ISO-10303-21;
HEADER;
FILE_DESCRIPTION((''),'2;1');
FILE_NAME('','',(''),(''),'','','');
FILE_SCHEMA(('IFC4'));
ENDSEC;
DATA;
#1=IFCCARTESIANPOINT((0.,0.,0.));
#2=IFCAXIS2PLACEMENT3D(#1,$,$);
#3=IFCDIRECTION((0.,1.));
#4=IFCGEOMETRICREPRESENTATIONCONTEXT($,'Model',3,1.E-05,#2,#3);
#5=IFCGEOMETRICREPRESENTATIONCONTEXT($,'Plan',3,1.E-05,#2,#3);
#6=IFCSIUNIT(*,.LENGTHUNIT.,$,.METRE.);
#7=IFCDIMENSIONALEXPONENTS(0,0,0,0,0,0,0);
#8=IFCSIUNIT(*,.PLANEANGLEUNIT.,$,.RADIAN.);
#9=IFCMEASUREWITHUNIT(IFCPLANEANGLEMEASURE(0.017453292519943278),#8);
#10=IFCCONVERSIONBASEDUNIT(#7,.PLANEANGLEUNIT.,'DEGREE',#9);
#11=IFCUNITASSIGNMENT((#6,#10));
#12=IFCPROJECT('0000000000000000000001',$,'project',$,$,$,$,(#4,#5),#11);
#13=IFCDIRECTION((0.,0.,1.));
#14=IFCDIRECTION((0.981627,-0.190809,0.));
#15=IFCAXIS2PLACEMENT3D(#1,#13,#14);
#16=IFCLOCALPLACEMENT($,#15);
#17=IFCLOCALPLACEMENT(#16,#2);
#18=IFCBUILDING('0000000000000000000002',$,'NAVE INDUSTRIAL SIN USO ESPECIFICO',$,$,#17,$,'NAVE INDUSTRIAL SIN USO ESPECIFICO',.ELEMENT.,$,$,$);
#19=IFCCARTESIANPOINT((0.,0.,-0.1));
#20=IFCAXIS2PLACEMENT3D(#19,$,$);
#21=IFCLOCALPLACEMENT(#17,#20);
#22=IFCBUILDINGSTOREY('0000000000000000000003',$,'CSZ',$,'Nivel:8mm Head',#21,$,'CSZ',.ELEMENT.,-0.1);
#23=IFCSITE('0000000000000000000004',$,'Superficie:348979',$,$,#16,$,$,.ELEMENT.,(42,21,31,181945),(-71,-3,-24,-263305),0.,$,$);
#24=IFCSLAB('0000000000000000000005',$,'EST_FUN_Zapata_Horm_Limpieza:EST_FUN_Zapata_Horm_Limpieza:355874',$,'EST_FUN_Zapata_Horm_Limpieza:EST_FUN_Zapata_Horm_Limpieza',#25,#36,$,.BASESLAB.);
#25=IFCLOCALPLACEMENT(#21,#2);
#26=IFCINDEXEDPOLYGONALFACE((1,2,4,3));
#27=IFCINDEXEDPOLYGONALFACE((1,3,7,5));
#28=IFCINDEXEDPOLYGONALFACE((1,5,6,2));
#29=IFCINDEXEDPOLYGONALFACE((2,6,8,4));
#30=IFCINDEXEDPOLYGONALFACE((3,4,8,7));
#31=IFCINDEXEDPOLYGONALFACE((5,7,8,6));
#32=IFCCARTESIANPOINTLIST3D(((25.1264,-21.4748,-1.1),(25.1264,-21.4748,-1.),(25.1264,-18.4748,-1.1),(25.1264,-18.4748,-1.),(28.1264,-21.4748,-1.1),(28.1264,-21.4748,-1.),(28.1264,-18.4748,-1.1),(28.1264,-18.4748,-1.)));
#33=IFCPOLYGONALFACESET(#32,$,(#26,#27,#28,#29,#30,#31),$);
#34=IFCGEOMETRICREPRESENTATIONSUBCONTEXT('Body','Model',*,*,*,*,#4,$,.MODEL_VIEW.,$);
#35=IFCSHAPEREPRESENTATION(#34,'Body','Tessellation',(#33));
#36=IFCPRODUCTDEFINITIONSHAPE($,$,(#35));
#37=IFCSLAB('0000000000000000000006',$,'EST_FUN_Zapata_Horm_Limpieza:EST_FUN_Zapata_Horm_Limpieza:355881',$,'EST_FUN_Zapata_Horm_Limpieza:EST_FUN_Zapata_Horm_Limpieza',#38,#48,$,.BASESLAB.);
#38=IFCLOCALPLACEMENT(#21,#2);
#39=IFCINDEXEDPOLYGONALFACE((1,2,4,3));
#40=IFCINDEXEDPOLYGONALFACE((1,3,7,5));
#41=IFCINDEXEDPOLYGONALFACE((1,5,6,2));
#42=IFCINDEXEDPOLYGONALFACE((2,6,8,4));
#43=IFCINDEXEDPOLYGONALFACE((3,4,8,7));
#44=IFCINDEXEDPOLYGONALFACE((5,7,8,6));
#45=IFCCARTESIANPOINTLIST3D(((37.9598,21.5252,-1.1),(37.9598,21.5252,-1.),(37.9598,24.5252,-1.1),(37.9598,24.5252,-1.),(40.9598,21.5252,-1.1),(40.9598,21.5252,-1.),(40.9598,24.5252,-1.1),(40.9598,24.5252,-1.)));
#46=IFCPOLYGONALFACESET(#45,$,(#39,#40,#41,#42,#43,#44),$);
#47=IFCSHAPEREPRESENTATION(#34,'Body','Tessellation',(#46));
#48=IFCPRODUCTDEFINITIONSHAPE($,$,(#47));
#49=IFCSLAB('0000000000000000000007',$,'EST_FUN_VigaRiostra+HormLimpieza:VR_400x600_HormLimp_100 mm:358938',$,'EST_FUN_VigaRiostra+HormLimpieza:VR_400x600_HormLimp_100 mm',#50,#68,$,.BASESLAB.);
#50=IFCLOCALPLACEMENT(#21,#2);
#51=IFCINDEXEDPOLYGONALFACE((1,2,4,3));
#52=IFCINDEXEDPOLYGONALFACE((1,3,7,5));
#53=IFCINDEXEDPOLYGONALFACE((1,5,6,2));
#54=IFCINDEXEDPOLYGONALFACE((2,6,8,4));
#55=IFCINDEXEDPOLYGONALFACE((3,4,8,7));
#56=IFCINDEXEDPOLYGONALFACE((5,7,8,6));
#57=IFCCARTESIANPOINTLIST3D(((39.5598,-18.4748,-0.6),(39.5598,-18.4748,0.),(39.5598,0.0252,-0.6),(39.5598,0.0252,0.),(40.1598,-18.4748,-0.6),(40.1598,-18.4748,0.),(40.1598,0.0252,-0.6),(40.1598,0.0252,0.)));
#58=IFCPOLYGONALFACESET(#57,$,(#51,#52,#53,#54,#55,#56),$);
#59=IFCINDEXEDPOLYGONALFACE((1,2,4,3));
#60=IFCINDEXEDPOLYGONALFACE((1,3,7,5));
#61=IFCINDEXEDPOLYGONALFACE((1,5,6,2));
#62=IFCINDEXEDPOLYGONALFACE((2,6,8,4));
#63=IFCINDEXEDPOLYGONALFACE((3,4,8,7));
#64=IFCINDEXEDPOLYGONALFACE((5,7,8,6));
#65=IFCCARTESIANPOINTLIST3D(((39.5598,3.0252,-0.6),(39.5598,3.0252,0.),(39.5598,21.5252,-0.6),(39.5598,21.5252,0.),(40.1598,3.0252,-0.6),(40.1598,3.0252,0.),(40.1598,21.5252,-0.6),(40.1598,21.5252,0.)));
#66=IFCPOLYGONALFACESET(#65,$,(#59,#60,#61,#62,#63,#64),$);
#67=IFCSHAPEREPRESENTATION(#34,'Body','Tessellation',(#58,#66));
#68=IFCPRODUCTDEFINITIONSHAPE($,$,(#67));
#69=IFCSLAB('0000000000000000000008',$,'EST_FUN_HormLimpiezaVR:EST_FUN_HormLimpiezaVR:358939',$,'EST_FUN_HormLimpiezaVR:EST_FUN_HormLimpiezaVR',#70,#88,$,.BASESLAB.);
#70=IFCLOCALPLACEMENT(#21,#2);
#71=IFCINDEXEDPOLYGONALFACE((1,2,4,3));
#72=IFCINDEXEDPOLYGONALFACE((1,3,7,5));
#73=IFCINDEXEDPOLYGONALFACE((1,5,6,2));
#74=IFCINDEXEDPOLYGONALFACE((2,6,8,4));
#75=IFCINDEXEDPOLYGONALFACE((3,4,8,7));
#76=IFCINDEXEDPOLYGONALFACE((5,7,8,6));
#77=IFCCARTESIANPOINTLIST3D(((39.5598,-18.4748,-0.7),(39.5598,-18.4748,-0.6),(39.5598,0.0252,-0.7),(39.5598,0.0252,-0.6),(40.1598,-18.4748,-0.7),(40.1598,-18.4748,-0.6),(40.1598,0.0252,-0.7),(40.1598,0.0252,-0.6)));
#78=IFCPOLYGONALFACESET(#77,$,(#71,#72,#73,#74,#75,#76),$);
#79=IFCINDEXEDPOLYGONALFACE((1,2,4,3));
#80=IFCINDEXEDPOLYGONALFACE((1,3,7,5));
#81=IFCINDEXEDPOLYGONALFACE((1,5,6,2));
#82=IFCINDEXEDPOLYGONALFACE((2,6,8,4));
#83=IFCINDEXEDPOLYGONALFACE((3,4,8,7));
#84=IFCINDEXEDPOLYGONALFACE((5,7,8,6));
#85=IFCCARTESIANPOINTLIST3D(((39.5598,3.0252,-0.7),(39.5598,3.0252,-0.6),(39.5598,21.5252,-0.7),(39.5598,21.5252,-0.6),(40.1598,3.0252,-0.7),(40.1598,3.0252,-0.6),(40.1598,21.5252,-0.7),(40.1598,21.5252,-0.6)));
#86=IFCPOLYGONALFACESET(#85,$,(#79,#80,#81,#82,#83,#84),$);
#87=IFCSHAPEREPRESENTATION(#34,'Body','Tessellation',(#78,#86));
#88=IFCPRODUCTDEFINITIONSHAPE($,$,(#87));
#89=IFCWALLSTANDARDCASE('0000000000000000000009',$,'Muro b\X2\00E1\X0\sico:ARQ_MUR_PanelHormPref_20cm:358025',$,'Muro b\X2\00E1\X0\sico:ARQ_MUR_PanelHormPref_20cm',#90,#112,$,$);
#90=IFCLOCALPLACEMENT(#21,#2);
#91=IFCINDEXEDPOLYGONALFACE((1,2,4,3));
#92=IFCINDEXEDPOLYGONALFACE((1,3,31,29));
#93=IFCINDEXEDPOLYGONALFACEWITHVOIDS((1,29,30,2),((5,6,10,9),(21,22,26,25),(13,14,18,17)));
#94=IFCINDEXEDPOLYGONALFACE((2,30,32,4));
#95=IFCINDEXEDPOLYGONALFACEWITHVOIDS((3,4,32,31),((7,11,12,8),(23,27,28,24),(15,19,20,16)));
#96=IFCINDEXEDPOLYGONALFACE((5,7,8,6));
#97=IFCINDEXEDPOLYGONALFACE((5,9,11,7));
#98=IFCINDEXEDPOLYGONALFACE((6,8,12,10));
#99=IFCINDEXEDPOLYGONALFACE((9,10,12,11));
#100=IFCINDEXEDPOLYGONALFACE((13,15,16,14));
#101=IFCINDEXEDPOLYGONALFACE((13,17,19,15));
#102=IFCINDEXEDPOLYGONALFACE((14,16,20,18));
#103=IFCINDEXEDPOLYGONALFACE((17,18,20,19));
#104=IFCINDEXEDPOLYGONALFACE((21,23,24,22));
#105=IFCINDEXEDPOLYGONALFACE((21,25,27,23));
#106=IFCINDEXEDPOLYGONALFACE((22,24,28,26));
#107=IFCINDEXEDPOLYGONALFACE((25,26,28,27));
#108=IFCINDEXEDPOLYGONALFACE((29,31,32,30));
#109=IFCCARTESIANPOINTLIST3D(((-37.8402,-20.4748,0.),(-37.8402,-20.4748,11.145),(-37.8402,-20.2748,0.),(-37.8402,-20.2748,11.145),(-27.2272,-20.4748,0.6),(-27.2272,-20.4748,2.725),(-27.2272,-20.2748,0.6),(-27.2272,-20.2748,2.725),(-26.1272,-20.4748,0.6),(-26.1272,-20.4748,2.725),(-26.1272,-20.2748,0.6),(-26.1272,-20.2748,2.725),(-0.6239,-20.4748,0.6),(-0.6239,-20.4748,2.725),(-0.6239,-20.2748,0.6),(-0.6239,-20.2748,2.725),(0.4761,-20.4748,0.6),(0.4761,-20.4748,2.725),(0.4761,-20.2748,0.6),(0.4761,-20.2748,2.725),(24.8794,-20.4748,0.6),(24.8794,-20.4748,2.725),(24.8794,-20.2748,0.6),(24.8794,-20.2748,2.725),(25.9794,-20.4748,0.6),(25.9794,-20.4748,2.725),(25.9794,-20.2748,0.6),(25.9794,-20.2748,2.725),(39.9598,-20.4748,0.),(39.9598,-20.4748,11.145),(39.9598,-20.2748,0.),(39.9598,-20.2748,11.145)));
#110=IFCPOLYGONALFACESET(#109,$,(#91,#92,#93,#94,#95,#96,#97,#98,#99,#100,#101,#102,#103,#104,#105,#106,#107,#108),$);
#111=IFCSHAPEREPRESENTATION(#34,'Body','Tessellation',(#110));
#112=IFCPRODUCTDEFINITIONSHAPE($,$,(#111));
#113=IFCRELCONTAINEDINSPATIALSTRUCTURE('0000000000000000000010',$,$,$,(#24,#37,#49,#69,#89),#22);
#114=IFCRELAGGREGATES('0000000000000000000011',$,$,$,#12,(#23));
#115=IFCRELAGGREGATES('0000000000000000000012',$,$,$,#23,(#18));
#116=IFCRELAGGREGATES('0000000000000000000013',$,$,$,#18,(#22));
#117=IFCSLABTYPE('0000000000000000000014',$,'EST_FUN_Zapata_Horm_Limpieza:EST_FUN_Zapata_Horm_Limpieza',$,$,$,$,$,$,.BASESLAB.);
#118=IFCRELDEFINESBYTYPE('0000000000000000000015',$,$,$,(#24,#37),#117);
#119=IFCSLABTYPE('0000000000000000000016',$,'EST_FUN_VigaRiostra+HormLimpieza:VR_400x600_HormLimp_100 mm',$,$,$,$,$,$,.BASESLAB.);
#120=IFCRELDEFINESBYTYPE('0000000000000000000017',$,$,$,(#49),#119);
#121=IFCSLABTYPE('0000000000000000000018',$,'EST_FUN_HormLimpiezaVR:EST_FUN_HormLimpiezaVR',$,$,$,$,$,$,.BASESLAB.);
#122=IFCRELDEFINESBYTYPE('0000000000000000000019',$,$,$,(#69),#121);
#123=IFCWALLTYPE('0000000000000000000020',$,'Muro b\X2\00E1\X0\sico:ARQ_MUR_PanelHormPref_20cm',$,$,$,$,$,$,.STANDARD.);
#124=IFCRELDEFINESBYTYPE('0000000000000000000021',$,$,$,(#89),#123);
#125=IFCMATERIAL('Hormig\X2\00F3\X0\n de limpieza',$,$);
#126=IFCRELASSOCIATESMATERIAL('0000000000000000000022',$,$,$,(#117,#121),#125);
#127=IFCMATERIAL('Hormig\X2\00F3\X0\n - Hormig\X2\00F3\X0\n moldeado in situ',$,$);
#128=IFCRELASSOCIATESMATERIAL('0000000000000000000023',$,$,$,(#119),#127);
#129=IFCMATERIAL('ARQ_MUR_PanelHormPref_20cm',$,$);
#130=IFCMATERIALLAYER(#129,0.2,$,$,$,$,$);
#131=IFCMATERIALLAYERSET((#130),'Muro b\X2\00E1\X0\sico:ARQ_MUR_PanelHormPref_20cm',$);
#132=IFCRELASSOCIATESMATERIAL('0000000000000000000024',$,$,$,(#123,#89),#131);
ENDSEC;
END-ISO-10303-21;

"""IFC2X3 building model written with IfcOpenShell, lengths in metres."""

from ifc_helpers import new_model, entity, si_unit, converted_unit, direction, frame, frame_2d, origin, origin_2d_with_axis, place, context, subcontext, project, spatial, rectangle, extrude, material, layer, layer_set, layer_usage, type_object, element, save


model = new_model("IFC2X3")

# Units and contexts
model_context = context("Model", 3, precision=1e-05, world=origin(), true_north=direction((0.0, 1.0)))
plan_context = context("Plan", 3, precision=1e-05, world=origin(), true_north=direction((0.0, 1.0)))
body_context = subcontext(model_context, "Body", "Model", "MODEL_VIEW")
ifc_project = project(units=[si_unit("LENGTHUNIT", "METRE"), converted_unit("PLANEANGLEUNIT", "DEGREE", entity("IfcPlaneAngleMeasure", 0.017453292519943278), si_unit("PLANEANGLEUNIT", "RADIAN"), dimensions=[0, 0, 0, 0, 0, 0, 0])], contexts=[model_context, plan_context])

# Site, building, storey
site_placement = place(None, frame((0.0, 0.0, 0.0), z_axis=(0.0, 0.0, 1.0), x_axis=(0.981627, -0.190809, 0.0)))
site = spatial("IfcSite", under=ifc_project, at=site_placement, Name="Superficie:348979", CompositionType="ELEMENT", RefLatitude=(42, 21, 31, 181945), RefLongitude=(-71, -3, -24, -263305), RefElevation=0.0)
building_placement = place(site_placement, origin())
building = spatial("IfcBuilding", under=site, at=building_placement, Name="NAVE INDUSTRIAL SIN USO ESPECIFICO", LongName="NAVE INDUSTRIAL SIN USO ESPECIFICO", CompositionType="ELEMENT")
storey_placement = place(building_placement, frame((0.0, 0.0, -0.1)))
storey = spatial("IfcBuildingStorey", under=building, at=storey_placement, Name="CSZ", ObjectType="Nivel:8mm Head", LongName="CSZ", CompositionType="ELEMENT", Elevation=-0.1)

# Slabs
ifc_material_1 = material(Name="Hormigón - Hormigón moldeado in situ")
ifc_material_2 = material(Name="Hormigón de limpieza")
slab_type_1 = type_object("IfcSlabType", Name="EST_FUN_Zapata_Horm_Limpieza:EST_FUN_Zapata_Horm_Limpieza", PredefinedType="BASESLAB", material=ifc_material_2)
slab_1_placement = place(storey_placement, frame((0.0, 0.0, -1.0)))
element("IfcSlab", 1, at=slab_1_placement, inside=storey, type_object=slab_type_1, Name="EST_FUN_Zapata_Horm_Limpieza:EST_FUN_Zapata_Horm_Limpieza:355874", ObjectType="EST_FUN_Zapata_Horm_Limpieza:EST_FUN_Zapata_Horm_Limpieza", PredefinedType="BASESLAB", context=body_context, shape_type="SweptSolid", body=[
    extrude(rectangle(XDim=3.0, YDim=3.0, at=frame_2d((0.0, 0.0), x_axis=(1.0, 0.0))), frame((26.6264, -19.9748, -0.1)), (0.0, 0.0, 1.0), 0.1),
])
slab_2_placement = place(storey_placement, frame((0.0, 0.0, -1.0)))
element("IfcSlab", 2, at=slab_2_placement, inside=storey, type_object=slab_type_1, Name="EST_FUN_Zapata_Horm_Limpieza:EST_FUN_Zapata_Horm_Limpieza:355881", ObjectType="EST_FUN_Zapata_Horm_Limpieza:EST_FUN_Zapata_Horm_Limpieza", PredefinedType="BASESLAB", context=body_context, shape_type="SweptSolid", body=[
    extrude(rectangle(XDim=3.0, YDim=3.0, at=frame_2d((0.0, 0.0), x_axis=(1.0, 0.0))), frame((39.4598, 23.0252, -0.1)), (0.0, 0.0, 1.0), 0.1),
])
slab_type_2 = type_object("IfcSlabType", Name="EST_FUN_VigaRiostra+HormLimpieza:VR_400x600_HormLimp_100 mm", PredefinedType="BASESLAB", material=ifc_material_1)
slab_3_placement = place(storey_placement, frame((39.5598, -18.4748, -0.6)))
element("IfcSlab", 3, at=slab_3_placement, inside=storey, type_object=slab_type_2, Name="EST_FUN_VigaRiostra+HormLimpieza:VR_400x600_HormLimp_100 mm:358938", ObjectType="EST_FUN_VigaRiostra+HormLimpieza:VR_400x600_HormLimp_100 mm", PredefinedType="BASESLAB", context=body_context, shape_type="SweptSolid", body=[
    extrude(rectangle(XDim=18.5, YDim=0.6, at=origin_2d_with_axis()), frame((0.3, 9.25, 0.0), z_axis=(0.0, 0.0, 1.0), x_axis=(0.0, -1.0, 0.0)), (0.0, 0.0, 1.0), 0.6),
    extrude(rectangle(XDim=18.5, YDim=0.6, at=origin_2d_with_axis()), frame((0.3, 30.75, 0.0), z_axis=(0.0, 0.0, 1.0), x_axis=(0.0, -1.0, 0.0)), (0.0, 0.0, 1.0), 0.6),
])
slab_type_3 = type_object("IfcSlabType", Name="EST_FUN_HormLimpiezaVR:EST_FUN_HormLimpiezaVR", PredefinedType="BASESLAB", material=ifc_material_2)
slab_4_placement = place(storey_placement, frame((39.5598, -18.4748, -0.7)))
element("IfcSlab", 4, at=slab_4_placement, inside=storey, type_object=slab_type_3, Name="EST_FUN_HormLimpiezaVR:EST_FUN_HormLimpiezaVR:358939", ObjectType="EST_FUN_HormLimpiezaVR:EST_FUN_HormLimpiezaVR", PredefinedType="BASESLAB", context=body_context, shape_type="SweptSolid", body=[
    extrude(rectangle(XDim=18.5, YDim=0.6, at=frame_2d((0.0, 0.0), x_axis=(1.0, 0.0))), frame((0.3, 9.25, 0.0), z_axis=(0.0, 0.0, 1.0), x_axis=(0.0, -1.0, 0.0)), (0.0, 0.0, 1.0), 0.1),
    extrude(rectangle(XDim=18.5, YDim=0.6, at=origin_2d_with_axis()), frame((0.3, 30.75, 0.0), z_axis=(0.0, 0.0, 1.0), x_axis=(0.0, -1.0, 0.0)), (0.0, 0.0, 1.0), 0.1),
])

# Wall, openings
ifc_material_3 = material(Name="ARQ_MUR_PanelHormPref_20cm")
ifc_layer = layer(ifc_material_3, 0.2)
ifc_layer_set = layer_set([ifc_layer], Name="Muro básico:ARQ_MUR_PanelHormPref_20cm")
ifc_layer_usage = layer_usage(ifc_layer_set, "AXIS2", "NEGATIVE", 0.1)
wall_type = type_object("IfcWallType", Name="Muro básico:ARQ_MUR_PanelHormPref_20cm", PredefinedType="STANDARD", material=ifc_layer_set)
wall_placement = place(storey_placement, frame((39.9598, -20.3748, 0.0), z_axis=(0.0, 0.0, 1.0), x_axis=(-1.0, 0.0, 0.0)))
wall = element("IfcWallStandardCase", 5, at=wall_placement, inside=storey, type_object=wall_type, material=ifc_layer_usage, Name="Muro básico:ARQ_MUR_PanelHormPref_20cm:358025", ObjectType="Muro básico:ARQ_MUR_PanelHormPref_20cm", context=body_context, shape_type="SweptSolid", body=[
    extrude(rectangle(XDim=77.8, YDim=0.2, at=frame_2d((38.9, 0.0), x_axis=(-1.0, 0.0))), origin(), (0.0, 0.0, 1.0), 11.145),
])
opening_1_placement = place(wall_placement, frame((13.9804, -0.1, 0.6)))
element("IfcOpeningElement", 6, at=opening_1_placement, cuts=wall, ObjectType="Opening", context=body_context, shape_type="SweptSolid", body=[
    extrude(rectangle(XDim=2.125, YDim=1.1, at=frame_2d((1.0625, 0.55), x_axis=(1.0, 0.0))), frame((0.0, 0.0, 0.0), z_axis=(0.0, 1.0, 0.0), x_axis=(0.0, 0.0, 1.0)), (0.0, 0.0, 1.0), 0.2),
])
opening_2_placement = place(wall_placement, frame((39.4837, -0.1, 0.6)))
element("IfcOpeningElement", 7, at=opening_2_placement, cuts=wall, ObjectType="Opening", context=body_context, shape_type="SweptSolid", body=[
    extrude(rectangle(XDim=2.125, YDim=1.1, at=frame_2d((1.0625, 0.55), x_axis=(1.0, 0.0))), frame((0.0, 0.0, 0.0), z_axis=(0.0, 1.0, 0.0), x_axis=(0.0, 0.0, 1.0)), (0.0, 0.0, 1.0), 0.2),
])
opening_3_placement = place(wall_placement, frame((66.087, -0.1, 0.6)))
element("IfcOpeningElement", 8, at=opening_3_placement, cuts=wall, ObjectType="Opening", context=body_context, shape_type="SweptSolid", body=[
    extrude(rectangle(XDim=2.125, YDim=1.1, at=frame_2d((1.0625, 0.55), x_axis=(1.0, 0.0))), frame((0.0, 0.0, 0.0), z_axis=(0.0, 1.0, 0.0), x_axis=(0.0, 0.0, 1.0)), (0.0, 0.0, 1.0), 0.2),
])

save(model, "model.ifc")
